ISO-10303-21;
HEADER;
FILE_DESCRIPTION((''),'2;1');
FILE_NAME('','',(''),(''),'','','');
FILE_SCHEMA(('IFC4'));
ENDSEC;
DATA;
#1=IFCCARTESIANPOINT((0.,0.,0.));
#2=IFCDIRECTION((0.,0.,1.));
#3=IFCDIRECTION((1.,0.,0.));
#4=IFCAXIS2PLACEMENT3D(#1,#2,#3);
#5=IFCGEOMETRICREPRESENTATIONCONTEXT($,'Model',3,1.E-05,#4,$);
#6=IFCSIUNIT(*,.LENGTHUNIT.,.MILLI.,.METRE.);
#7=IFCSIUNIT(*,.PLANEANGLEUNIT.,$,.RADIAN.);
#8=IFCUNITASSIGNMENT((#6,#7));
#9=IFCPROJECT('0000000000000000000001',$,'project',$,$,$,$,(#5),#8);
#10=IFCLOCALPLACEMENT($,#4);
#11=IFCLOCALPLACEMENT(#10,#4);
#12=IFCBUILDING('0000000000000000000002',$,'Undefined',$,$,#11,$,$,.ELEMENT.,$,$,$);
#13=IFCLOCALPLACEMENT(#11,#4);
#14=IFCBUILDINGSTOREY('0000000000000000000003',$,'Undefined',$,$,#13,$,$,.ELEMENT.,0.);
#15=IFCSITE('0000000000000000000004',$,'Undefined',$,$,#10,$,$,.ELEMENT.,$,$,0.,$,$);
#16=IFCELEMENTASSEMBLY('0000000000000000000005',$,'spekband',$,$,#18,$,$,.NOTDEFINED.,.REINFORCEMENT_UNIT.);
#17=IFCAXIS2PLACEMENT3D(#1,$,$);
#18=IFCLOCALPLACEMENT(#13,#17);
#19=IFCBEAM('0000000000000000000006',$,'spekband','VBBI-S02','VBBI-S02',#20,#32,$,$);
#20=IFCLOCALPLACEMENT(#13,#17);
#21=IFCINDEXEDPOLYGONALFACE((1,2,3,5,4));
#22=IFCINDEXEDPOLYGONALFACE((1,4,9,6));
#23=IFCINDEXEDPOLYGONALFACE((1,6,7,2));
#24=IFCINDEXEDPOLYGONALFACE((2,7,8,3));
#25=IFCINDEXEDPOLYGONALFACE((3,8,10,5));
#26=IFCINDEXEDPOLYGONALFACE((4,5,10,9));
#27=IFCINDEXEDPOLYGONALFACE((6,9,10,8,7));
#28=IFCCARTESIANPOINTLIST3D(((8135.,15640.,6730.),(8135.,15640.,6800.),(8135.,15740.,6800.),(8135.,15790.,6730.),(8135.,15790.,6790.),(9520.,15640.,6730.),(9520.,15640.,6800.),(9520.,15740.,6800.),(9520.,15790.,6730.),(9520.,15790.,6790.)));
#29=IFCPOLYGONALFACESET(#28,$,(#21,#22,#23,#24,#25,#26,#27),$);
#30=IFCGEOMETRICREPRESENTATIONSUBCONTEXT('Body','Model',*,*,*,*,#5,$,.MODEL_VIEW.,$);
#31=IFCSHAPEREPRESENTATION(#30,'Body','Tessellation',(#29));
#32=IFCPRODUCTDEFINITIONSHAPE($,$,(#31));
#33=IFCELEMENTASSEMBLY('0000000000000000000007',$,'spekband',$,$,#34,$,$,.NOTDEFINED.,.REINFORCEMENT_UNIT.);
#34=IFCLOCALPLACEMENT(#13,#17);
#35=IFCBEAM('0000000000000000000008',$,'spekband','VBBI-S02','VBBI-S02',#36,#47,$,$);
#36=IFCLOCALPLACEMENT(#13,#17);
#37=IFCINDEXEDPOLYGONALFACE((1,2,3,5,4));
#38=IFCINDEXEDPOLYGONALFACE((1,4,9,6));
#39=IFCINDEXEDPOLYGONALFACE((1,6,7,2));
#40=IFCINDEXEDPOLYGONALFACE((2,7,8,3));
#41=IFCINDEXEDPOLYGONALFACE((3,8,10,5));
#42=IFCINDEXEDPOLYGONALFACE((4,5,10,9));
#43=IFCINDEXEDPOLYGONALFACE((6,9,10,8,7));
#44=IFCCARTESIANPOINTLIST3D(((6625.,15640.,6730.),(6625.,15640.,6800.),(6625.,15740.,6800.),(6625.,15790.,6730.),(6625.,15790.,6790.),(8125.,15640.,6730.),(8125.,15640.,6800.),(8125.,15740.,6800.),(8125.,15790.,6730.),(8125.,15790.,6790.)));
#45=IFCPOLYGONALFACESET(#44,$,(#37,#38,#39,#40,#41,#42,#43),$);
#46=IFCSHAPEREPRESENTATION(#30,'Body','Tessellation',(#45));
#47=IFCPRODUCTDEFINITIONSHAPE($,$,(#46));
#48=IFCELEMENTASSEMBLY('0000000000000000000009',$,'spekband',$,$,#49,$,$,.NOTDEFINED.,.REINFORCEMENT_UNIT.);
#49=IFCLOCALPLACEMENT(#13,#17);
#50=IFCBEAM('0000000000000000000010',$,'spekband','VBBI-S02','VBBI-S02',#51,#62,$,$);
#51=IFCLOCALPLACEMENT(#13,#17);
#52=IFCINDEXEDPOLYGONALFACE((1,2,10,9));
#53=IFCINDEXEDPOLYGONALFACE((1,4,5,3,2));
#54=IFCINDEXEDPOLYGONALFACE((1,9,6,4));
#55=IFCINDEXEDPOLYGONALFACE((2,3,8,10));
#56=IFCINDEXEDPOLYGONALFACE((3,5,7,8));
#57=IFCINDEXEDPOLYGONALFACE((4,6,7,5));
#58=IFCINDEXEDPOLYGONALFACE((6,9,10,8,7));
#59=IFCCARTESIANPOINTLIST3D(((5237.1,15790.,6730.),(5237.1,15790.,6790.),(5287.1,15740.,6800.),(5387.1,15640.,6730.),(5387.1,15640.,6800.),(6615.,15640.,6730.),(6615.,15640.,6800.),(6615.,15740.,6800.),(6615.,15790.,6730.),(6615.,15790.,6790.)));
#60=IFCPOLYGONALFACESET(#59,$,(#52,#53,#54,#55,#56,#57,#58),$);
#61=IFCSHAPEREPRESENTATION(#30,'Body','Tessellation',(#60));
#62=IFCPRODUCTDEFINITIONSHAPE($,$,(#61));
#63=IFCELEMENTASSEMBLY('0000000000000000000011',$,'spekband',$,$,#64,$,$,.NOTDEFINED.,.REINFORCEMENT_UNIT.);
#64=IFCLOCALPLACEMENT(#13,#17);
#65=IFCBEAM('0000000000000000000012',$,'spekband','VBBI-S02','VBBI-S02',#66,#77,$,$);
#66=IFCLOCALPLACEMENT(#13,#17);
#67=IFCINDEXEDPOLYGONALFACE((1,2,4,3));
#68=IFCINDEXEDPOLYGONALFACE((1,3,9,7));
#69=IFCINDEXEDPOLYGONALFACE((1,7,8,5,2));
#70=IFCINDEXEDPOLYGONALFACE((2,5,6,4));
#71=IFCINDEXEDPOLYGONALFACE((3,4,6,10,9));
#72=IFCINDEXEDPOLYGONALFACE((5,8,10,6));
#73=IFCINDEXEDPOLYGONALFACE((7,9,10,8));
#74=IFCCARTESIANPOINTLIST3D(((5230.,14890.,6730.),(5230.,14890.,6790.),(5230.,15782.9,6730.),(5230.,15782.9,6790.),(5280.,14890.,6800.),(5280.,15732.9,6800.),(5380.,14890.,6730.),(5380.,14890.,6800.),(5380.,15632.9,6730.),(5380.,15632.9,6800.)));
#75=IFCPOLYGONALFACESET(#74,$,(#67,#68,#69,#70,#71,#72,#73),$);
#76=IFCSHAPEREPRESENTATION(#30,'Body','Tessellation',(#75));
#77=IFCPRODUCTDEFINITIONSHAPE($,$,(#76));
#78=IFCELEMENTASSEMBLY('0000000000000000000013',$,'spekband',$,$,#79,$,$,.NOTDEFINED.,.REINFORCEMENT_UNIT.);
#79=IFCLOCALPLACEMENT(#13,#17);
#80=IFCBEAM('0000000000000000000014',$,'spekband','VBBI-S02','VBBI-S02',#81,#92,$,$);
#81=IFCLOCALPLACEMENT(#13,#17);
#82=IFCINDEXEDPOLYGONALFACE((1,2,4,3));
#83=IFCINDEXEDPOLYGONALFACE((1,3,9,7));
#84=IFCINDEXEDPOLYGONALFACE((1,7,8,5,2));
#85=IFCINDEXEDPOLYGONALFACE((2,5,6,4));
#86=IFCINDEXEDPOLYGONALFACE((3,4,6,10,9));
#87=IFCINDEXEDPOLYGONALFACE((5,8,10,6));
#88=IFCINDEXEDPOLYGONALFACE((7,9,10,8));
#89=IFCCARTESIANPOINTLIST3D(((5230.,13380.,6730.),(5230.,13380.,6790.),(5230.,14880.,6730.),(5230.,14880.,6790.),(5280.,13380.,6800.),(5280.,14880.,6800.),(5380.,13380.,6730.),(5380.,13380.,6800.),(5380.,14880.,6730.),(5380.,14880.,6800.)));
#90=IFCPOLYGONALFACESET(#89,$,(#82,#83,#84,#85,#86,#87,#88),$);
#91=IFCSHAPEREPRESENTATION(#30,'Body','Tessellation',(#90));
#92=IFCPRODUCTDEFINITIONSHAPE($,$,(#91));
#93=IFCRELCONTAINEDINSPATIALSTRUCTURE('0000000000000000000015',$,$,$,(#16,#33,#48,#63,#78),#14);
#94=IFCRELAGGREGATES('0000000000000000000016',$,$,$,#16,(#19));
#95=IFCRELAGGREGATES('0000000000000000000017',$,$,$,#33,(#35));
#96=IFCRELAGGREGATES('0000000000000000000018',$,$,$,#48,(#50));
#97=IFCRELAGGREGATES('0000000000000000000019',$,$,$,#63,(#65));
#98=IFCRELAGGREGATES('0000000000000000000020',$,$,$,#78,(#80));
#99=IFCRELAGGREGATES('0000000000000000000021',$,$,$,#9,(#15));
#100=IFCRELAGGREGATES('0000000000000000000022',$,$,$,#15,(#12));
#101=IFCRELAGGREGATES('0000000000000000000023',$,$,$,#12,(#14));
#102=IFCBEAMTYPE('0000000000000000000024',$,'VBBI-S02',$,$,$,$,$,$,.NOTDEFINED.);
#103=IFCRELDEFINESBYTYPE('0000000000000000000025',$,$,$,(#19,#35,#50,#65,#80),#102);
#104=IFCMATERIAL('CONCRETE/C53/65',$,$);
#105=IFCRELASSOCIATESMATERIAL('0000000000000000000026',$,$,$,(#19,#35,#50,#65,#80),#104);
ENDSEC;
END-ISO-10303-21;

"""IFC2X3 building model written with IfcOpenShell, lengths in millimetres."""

from ifc_helpers import new_model, si_unit, frame, origin_with_axes, place, context, subcontext, project, spatial, polyline, outline, extrude, clip, halfspace, material, type_object, element, aggregate, save


model = new_model("IFC2X3")

# Units and contexts
model_context = context("Model", 3, precision=1e-05, world=origin_with_axes())
body_context = subcontext(model_context, "Body", "Model", "MODEL_VIEW")
ifc_project = project(units=[si_unit("LENGTHUNIT", "METRE", prefix="MILLI"), si_unit("PLANEANGLEUNIT", "RADIAN")], contexts=[model_context])

# Site, building, storey
site_placement = place(None, origin_with_axes())
site = spatial("IfcSite", under=ifc_project, at=site_placement, Name="Undefined", CompositionType="ELEMENT", RefElevation=0.0)
building_placement = place(site_placement, origin_with_axes())
building = spatial("IfcBuilding", under=site, at=building_placement, Name="Undefined", CompositionType="ELEMENT")
storey_placement = place(building_placement, origin_with_axes())
storey = spatial("IfcBuildingStorey", under=building, at=storey_placement, Name="Undefined", CompositionType="ELEMENT", Elevation=0.0)

# Element assemblies, beams
ifc_material_1 = material(Name="CONCRETE/C53/65")
beam_type = type_object("IfcBeamType", Name="VBBI-S02", PredefinedType="NOTDEFINED")
assembly_1_placement = place(storey_placement, origin_with_axes())
assembly_1 = element("IfcElementAssembly", 1, at=assembly_1_placement, inside=storey, Name="spekband", AssemblyPlace="NOTDEFINED", PredefinedType="REINFORCEMENT_UNIT")
beam_1_placement = place(assembly_1_placement, frame((9520.0, 15715.0, 6765.0), z_axis=(0.0, 1.0, 0.0), x_axis=(-1.0, 0.0, 0.0)))
beam_1 = element("IfcBeam", 2, at=beam_1_placement, type_object=beam_type, material=ifc_material_1, Name="spekband", Description="VBBI-S02", ObjectType="VBBI-S02", context=body_context, shape_type="SweptSolid", body=[
    extrude(outline(polyline([(35.0, -75.0), (-35.0, -75.0), (-35.0, 25.0), (-25.0, 75.0), (35.0, 75.0), (35.0, -75.0)])), frame((1385.0, 0.0, 0.0), z_axis=(-1.0, 0.0, 0.0), x_axis=(0.0, -1.0, 0.0)), (0.0, 0.0, 1.0), 1385.0),
])
aggregate(assembly_1, [beam_1])
assembly_2_placement = place(storey_placement, origin_with_axes())
assembly_2 = element("IfcElementAssembly", 3, at=assembly_2_placement, inside=storey, Name="spekband", AssemblyPlace="NOTDEFINED", PredefinedType="REINFORCEMENT_UNIT")
beam_2_placement = place(assembly_2_placement, frame((8125.0, 15715.0, 6765.0), z_axis=(0.0, 1.0, 0.0), x_axis=(-1.0, 0.0, 0.0)))
beam_2 = element("IfcBeam", 4, at=beam_2_placement, type_object=beam_type, material=ifc_material_1, Name="spekband", Description="VBBI-S02", ObjectType="VBBI-S02", context=body_context, shape_type="SweptSolid", body=[
    extrude(outline(polyline([(35.0, -75.0), (-35.0, -75.0), (-35.0, 25.0), (-25.0, 75.0), (35.0, 75.0), (35.0, -75.0)])), frame((1500.0, 0.0, 0.0), z_axis=(-1.0, 0.0, 0.0), x_axis=(0.0, -1.0, 0.0)), (0.0, 0.0, 1.0), 1500.0),
])
aggregate(assembly_2, [beam_2])
assembly_3_placement = place(storey_placement, origin_with_axes())
assembly_3 = element("IfcElementAssembly", 5, at=assembly_3_placement, inside=storey, Name="spekband", AssemblyPlace="NOTDEFINED", PredefinedType="REINFORCEMENT_UNIT")
beam_3_placement = place(assembly_3_placement, frame((6615.0, 15715.0, 6765.0), z_axis=(0.0, 1.0, 0.0), x_axis=(-1.0, 0.0, 0.0)))
beam_3 = element("IfcBeam", 6, at=beam_3_placement, type_object=beam_type, material=ifc_material_1, Name="spekband", Description="VBBI-S02", ObjectType="VBBI-S02", context=body_context, shape_type="Clipping", body=[
    clip(extrude(outline(polyline([(35.0, -75.0), (-35.0, -75.0), (-35.0, 25.0), (-25.0, 75.0), (35.0, 75.0), (35.0, -75.0)])), frame((1378.7, 0.0, 0.0), z_axis=(-1.0, 0.0, 0.0), x_axis=(0.0, -1.0, 0.0)), (0.0, 0.0, 1.0), 1378.7), halfspace(frame((1381.5, 0.0, 78.5), z_axis=(0.707106, 0.0, -0.707107), x_axis=(0.0, 1.0, 0.0)), False)),
])
aggregate(assembly_3, [beam_3])
assembly_4_placement = place(storey_placement, origin_with_axes())
assembly_4 = element("IfcElementAssembly", 7, at=assembly_4_placement, inside=storey, Name="spekband", AssemblyPlace="NOTDEFINED", PredefinedType="REINFORCEMENT_UNIT")
beam_4_placement = place(assembly_4_placement, frame((5305.0, 15790.0, 6765.0), z_axis=(-1.0, 0.0, 0.0), x_axis=(0.0, -1.0, 0.0)))
beam_4 = element("IfcBeam", 8, at=beam_4_placement, type_object=beam_type, material=ifc_material_1, Name="spekband", Description="VBBI-S02", ObjectType="VBBI-S02", context=body_context, shape_type="Clipping", body=[
    clip(extrude(outline(polyline([(35.0, -75.0), (-35.0, -75.0), (-35.0, 25.0), (-25.0, 75.0), (35.0, 75.0), (35.0, -75.0)])), frame((900.0, 0.0, 0.0), z_axis=(-1.0, 0.0, 0.0), x_axis=(0.0, -1.0, 0.0)), (0.0, 0.0, 1.0), 893.7), halfspace(frame((3.5, 0.0, 78.5), z_axis=(0.707107, 0.0, 0.707107), x_axis=(0.0, 1.0, 0.0)), True)),
])
aggregate(assembly_4, [beam_4])
assembly_5_placement = place(storey_placement, origin_with_axes())
assembly_5 = element("IfcElementAssembly", 9, at=assembly_5_placement, inside=storey, Name="spekband", AssemblyPlace="NOTDEFINED", PredefinedType="REINFORCEMENT_UNIT")
beam_5_placement = place(assembly_5_placement, frame((5305.0, 14880.0, 6765.0), z_axis=(-1.0, 0.0, 0.0), x_axis=(0.0, -1.0, 0.0)))
beam_5 = element("IfcBeam", 10, at=beam_5_placement, type_object=beam_type, material=ifc_material_1, Name="spekband", Description="VBBI-S02", ObjectType="VBBI-S02", context=body_context, shape_type="SweptSolid", body=[
    extrude(outline(polyline([(35.0, -75.0), (-35.0, -75.0), (-35.0, 25.0), (-25.0, 75.0), (35.0, 75.0), (35.0, -75.0)])), frame((1500.0, 0.0, 0.0), z_axis=(-1.0, 0.0, 0.0), x_axis=(0.0, -1.0, 0.0)), (0.0, 0.0, 1.0), 1500.0),
])
aggregate(assembly_5, [beam_5])

save(model, "model.ifc")
